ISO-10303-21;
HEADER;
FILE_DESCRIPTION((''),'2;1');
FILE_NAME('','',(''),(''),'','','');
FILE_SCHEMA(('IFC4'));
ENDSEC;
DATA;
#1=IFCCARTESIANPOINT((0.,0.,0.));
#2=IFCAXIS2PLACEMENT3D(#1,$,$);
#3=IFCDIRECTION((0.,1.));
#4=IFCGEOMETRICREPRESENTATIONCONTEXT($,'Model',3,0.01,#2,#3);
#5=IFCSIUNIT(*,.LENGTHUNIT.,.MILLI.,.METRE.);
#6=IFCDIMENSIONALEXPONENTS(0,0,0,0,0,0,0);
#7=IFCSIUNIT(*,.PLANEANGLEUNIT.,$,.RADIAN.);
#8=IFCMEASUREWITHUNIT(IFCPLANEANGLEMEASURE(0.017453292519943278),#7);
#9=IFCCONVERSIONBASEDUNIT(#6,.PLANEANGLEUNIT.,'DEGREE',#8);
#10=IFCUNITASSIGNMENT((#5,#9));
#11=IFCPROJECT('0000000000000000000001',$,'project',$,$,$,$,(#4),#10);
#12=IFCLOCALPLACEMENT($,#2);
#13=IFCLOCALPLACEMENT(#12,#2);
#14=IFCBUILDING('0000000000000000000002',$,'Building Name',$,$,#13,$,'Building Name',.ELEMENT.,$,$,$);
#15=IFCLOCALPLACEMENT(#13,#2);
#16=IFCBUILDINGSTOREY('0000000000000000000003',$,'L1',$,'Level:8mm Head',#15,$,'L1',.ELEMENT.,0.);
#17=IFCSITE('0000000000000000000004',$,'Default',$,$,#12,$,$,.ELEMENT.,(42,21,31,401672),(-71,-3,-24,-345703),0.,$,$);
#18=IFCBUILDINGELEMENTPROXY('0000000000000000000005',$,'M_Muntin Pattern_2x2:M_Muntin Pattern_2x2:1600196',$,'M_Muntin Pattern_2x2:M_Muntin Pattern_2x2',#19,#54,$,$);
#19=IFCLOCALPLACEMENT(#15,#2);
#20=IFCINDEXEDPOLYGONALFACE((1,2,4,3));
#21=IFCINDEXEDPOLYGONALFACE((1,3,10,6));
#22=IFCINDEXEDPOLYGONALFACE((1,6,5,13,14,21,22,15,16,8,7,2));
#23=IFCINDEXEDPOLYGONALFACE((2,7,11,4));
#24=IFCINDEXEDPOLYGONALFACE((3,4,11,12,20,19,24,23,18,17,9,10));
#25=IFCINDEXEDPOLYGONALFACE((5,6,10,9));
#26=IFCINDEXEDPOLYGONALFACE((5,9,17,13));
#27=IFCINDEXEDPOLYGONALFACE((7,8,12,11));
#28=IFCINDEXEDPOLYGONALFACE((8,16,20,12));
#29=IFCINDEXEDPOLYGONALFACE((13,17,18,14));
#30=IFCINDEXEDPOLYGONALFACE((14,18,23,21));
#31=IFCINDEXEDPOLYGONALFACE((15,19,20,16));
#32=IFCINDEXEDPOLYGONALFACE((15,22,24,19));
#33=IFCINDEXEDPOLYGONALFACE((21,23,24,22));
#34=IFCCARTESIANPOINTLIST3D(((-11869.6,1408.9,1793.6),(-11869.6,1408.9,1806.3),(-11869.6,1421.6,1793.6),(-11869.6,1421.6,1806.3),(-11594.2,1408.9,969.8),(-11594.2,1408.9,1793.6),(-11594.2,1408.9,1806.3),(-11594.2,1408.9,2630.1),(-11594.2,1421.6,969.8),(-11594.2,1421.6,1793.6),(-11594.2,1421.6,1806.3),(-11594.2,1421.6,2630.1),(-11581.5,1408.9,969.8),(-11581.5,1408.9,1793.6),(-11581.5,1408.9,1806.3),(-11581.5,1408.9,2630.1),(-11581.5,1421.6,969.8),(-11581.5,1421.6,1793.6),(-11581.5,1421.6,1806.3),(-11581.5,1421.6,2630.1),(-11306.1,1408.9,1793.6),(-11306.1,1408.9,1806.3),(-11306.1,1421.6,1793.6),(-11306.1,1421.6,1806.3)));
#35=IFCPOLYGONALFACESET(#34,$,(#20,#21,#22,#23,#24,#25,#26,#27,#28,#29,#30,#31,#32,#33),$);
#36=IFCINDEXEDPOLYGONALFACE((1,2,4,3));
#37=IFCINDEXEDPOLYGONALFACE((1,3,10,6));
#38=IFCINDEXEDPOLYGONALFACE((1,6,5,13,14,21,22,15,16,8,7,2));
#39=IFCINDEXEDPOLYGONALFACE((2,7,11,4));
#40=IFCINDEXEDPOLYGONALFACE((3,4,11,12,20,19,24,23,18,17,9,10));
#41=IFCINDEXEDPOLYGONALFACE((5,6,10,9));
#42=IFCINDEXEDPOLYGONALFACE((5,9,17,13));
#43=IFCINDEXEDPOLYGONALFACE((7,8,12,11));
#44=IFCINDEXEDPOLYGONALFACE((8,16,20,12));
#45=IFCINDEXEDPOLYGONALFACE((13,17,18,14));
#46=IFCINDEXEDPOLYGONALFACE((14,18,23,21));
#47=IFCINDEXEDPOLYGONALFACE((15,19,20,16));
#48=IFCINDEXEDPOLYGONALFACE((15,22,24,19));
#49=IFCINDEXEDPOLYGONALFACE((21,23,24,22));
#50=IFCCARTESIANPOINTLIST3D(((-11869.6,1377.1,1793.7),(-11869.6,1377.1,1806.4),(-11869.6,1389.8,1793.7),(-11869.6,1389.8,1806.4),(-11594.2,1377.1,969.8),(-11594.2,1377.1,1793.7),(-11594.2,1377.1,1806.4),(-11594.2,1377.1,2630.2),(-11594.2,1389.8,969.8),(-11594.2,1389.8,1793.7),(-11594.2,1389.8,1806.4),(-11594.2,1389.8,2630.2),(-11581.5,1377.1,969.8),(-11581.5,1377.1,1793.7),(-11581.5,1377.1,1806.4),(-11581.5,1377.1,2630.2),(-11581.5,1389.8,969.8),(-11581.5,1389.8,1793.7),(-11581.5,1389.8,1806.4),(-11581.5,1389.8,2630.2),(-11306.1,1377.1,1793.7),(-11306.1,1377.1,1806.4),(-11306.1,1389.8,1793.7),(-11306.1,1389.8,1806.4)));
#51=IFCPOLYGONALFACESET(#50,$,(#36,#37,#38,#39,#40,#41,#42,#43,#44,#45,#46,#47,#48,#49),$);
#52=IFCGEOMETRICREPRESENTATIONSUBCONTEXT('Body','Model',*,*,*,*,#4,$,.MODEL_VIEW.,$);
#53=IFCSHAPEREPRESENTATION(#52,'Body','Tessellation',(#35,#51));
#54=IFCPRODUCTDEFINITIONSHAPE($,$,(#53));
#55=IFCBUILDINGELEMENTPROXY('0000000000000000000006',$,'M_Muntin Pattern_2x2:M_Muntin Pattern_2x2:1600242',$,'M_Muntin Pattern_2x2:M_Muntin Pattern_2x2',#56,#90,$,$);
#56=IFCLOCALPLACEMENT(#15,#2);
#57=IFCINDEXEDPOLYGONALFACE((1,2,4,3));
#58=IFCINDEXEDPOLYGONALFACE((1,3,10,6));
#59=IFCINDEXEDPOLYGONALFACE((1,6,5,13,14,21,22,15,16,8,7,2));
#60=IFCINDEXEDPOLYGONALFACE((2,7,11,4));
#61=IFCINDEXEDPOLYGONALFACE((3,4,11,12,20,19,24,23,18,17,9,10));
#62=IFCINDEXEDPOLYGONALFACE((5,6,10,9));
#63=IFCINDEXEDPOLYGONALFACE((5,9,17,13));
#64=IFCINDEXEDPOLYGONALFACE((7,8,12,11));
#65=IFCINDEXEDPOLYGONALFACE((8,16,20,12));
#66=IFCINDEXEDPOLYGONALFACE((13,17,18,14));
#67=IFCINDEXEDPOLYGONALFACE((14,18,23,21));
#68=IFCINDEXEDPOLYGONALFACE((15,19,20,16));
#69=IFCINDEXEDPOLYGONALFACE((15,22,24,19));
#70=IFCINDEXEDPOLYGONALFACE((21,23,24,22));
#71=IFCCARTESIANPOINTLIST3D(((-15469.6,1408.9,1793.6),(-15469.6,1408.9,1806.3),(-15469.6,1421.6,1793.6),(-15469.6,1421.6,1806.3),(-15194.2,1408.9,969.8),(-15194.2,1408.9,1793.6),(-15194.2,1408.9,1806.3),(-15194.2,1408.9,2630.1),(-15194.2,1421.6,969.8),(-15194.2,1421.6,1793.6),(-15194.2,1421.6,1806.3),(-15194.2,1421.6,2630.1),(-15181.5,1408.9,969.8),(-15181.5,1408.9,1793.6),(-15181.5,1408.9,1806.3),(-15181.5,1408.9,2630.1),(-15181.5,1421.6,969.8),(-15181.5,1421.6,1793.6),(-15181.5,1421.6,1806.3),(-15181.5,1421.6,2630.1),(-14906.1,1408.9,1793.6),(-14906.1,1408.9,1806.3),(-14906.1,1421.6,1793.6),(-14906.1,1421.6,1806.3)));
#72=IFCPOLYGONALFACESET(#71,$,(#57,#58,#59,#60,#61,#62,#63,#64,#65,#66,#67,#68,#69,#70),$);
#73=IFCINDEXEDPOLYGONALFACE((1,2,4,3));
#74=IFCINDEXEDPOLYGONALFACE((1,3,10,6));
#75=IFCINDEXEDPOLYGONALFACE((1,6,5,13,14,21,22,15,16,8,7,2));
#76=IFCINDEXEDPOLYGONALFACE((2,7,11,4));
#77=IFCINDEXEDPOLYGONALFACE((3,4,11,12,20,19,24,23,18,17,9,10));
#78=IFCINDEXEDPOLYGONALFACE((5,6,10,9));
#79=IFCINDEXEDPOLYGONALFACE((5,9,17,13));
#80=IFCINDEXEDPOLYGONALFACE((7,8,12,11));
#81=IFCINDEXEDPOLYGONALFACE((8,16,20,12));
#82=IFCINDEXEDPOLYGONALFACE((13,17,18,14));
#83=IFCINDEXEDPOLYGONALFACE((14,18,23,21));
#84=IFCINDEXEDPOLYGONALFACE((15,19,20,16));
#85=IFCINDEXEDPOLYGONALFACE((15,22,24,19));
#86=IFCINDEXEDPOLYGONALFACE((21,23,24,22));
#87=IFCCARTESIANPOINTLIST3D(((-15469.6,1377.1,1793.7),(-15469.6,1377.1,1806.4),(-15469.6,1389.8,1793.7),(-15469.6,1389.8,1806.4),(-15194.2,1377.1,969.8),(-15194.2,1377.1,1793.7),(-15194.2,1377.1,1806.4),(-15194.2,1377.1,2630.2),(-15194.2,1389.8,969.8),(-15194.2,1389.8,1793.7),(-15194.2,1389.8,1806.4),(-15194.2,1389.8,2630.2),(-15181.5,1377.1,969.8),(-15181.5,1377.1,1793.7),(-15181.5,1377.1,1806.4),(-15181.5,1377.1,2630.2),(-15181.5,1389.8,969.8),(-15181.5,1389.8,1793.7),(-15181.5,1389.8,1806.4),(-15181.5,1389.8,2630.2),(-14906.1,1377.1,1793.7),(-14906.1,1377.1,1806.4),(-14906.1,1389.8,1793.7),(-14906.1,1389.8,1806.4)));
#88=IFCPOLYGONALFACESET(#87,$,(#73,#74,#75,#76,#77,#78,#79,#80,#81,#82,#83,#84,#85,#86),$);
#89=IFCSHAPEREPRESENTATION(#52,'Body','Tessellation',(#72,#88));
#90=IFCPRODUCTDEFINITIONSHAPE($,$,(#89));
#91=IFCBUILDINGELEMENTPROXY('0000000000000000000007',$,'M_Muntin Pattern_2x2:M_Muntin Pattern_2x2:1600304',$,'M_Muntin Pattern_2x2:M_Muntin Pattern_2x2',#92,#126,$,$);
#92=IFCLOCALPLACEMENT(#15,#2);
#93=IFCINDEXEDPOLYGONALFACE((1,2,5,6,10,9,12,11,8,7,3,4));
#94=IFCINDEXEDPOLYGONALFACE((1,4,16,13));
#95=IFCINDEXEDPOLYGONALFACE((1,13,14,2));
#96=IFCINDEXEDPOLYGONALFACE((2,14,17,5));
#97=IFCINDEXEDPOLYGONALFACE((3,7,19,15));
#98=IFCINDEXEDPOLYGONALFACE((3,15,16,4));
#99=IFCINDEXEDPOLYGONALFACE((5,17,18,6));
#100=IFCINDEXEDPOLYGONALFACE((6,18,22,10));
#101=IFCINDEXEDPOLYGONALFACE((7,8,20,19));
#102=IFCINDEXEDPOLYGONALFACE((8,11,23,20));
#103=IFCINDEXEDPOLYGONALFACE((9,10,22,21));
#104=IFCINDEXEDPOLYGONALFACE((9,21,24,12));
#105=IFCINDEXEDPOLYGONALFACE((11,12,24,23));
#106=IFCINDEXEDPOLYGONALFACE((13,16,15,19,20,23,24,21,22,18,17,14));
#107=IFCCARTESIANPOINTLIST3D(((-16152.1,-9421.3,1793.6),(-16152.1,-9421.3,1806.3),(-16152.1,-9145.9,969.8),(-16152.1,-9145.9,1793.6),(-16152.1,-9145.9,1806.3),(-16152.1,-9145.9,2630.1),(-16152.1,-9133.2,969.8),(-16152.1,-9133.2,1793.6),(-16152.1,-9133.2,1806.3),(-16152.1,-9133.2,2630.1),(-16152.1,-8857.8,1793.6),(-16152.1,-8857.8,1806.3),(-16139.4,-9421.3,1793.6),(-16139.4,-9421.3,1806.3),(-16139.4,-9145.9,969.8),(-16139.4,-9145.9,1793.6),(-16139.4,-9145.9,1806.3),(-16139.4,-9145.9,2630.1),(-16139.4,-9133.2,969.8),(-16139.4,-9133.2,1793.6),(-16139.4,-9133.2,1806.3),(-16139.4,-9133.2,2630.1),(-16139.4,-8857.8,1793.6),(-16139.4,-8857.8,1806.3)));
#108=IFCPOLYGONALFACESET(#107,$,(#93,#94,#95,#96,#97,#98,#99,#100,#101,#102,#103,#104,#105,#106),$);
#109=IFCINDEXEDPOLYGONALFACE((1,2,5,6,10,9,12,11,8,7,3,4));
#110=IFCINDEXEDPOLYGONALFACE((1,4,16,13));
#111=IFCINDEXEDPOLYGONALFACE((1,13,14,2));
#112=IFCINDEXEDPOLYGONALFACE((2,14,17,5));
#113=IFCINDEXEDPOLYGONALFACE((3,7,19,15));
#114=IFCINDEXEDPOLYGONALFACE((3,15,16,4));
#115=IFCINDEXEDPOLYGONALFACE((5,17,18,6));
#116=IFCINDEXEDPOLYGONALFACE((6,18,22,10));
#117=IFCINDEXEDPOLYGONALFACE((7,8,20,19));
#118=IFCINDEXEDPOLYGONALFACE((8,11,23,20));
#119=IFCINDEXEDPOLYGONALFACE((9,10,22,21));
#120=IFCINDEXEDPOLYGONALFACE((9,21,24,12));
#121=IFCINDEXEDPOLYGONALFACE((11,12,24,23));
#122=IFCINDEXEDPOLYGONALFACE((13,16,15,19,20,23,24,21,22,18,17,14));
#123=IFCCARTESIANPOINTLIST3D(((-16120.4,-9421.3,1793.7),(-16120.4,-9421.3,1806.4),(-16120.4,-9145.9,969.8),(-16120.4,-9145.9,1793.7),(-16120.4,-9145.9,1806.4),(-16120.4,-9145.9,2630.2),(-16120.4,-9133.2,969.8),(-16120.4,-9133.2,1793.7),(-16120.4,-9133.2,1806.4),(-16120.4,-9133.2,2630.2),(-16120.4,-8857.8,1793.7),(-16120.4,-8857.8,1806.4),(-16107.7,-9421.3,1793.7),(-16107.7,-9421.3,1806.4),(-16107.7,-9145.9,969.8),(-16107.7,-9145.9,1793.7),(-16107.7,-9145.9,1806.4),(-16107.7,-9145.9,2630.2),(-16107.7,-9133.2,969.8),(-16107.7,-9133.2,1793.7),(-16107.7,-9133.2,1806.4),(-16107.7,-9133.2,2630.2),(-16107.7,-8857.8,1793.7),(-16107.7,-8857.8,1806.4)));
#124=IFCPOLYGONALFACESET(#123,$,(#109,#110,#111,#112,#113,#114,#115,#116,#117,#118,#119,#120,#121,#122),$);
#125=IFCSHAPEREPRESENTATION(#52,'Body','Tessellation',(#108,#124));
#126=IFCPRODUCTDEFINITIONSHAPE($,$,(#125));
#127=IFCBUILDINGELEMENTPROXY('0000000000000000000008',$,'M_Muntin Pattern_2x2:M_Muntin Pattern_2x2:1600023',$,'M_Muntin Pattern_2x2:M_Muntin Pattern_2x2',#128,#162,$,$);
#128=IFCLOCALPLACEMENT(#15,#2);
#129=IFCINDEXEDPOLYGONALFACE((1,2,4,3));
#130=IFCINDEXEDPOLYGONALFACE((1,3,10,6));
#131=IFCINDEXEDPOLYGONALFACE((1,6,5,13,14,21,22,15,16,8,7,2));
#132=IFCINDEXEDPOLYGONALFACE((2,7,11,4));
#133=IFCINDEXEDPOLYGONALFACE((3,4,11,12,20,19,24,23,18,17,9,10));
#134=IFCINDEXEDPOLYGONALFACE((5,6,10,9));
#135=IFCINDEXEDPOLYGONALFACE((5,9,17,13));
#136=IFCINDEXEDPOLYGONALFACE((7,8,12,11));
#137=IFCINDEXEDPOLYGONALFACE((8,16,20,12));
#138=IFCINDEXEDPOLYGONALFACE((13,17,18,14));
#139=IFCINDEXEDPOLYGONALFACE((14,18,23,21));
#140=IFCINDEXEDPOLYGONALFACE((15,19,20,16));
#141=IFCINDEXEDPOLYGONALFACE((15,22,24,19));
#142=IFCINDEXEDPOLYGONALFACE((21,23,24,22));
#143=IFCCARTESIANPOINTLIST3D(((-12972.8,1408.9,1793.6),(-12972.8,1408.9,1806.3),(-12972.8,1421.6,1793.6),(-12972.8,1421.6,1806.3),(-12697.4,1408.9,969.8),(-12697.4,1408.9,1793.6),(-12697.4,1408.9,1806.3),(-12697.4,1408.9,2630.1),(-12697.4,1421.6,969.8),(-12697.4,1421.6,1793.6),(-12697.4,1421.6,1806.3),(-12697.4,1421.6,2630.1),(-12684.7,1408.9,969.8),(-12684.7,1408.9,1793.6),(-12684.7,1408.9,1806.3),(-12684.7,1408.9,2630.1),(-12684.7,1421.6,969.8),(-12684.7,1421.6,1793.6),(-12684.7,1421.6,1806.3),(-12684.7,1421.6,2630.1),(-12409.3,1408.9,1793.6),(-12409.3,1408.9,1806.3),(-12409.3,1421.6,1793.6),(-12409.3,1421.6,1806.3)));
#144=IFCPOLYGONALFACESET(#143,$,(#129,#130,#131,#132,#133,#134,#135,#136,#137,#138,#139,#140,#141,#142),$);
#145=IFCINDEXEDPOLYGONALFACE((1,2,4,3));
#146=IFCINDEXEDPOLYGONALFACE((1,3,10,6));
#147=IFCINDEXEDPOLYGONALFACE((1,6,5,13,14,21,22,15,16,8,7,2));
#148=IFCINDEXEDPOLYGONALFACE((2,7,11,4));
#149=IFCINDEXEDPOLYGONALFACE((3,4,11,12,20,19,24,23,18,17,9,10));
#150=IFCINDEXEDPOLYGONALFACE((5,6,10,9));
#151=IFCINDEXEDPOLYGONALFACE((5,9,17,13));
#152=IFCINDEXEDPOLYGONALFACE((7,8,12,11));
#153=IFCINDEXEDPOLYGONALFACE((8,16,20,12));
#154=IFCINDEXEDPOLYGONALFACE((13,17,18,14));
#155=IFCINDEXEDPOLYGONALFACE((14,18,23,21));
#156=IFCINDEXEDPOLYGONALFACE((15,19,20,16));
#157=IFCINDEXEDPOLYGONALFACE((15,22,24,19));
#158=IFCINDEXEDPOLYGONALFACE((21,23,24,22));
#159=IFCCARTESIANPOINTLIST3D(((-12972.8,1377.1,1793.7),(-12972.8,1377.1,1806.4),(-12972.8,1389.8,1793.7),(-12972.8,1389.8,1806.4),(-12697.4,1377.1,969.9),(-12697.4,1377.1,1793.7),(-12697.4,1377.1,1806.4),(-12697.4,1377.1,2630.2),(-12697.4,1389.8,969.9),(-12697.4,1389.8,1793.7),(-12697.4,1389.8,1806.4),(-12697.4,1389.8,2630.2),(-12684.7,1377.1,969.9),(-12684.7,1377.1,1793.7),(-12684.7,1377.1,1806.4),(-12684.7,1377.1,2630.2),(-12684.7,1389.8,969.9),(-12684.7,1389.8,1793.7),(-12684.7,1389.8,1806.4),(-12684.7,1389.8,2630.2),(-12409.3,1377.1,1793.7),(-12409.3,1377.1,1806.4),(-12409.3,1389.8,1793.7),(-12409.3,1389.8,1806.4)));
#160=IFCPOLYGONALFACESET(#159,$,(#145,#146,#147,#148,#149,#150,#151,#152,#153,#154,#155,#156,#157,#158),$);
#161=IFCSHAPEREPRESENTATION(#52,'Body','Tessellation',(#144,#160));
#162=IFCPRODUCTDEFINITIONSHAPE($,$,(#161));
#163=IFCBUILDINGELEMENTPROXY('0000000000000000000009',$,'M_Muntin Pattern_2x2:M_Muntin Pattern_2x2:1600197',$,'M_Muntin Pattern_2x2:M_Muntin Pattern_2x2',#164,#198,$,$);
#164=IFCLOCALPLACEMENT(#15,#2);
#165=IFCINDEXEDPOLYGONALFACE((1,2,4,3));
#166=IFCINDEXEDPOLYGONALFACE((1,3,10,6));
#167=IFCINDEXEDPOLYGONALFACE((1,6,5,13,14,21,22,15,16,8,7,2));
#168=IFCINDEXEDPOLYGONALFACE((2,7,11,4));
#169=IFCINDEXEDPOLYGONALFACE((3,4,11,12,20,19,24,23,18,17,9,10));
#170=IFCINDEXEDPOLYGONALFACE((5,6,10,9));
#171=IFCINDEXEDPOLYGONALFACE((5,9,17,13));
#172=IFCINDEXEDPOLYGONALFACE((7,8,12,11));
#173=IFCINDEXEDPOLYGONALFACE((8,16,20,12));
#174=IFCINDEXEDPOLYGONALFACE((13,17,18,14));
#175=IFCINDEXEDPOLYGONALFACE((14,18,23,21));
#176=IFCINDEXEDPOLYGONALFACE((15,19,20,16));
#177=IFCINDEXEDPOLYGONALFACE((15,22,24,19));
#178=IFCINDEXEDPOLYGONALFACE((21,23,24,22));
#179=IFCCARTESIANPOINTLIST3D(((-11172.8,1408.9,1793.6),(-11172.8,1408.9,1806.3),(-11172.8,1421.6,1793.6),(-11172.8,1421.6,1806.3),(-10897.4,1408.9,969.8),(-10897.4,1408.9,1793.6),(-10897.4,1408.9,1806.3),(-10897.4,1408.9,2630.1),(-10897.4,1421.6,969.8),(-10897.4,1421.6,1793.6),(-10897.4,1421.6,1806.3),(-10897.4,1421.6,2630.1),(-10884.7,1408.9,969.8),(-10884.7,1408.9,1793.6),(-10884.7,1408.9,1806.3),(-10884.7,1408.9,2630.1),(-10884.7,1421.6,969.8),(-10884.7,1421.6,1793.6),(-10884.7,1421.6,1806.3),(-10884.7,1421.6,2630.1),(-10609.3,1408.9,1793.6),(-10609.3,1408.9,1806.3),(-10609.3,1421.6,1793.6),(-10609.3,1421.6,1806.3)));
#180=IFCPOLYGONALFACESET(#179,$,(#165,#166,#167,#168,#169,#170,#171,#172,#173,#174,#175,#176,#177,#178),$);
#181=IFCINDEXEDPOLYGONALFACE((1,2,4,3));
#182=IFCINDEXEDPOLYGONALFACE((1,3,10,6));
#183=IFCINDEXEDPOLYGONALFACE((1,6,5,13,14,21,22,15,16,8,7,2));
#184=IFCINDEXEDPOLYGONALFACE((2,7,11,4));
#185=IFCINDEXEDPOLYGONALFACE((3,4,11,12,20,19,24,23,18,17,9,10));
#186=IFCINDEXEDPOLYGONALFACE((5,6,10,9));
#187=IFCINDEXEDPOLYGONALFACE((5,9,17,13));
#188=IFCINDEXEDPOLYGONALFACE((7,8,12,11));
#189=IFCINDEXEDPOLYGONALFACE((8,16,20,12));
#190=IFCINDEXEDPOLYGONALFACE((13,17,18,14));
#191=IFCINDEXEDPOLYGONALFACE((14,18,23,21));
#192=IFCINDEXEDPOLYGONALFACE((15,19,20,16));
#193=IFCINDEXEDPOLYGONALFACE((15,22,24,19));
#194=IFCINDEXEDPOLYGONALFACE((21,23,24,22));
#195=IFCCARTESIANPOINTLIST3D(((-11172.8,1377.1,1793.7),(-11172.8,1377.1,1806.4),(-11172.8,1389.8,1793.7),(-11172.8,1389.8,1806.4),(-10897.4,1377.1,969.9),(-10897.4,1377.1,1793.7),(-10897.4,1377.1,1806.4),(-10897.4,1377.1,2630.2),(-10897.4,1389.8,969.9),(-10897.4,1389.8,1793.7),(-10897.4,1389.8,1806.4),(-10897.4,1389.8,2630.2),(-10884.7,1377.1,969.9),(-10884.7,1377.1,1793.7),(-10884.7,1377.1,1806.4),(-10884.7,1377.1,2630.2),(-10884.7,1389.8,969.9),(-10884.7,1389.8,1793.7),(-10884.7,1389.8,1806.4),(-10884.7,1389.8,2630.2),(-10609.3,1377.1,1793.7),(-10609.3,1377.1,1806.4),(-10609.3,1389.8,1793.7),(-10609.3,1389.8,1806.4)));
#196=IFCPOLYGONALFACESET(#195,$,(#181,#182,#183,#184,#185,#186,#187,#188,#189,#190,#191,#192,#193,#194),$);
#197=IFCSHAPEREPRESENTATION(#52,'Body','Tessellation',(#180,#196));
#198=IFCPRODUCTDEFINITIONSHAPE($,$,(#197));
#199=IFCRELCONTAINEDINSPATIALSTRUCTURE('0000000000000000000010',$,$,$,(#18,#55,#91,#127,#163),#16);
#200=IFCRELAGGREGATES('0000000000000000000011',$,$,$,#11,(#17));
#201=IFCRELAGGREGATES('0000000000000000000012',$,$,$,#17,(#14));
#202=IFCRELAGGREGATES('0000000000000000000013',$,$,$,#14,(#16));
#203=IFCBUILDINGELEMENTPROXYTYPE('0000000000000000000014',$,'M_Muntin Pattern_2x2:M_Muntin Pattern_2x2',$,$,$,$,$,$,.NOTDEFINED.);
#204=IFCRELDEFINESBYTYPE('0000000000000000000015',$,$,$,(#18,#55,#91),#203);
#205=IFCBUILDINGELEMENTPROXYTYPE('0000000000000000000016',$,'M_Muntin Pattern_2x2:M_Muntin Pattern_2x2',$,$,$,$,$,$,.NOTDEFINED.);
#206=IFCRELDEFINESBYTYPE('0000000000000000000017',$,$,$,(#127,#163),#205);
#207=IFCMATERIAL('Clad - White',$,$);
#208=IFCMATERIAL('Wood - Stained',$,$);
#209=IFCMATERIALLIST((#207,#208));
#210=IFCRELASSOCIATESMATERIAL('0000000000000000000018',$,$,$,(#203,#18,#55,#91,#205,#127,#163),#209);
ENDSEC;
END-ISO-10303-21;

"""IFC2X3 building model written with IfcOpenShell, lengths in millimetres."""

from ifc_helpers import new_model, entity, si_unit, converted_unit, direction, frame, origin, place, context, subcontext, project, spatial, polyline, outline, extrude, source, transform, mapped, material, material_list, type_object, type_shapes, element, save


model = new_model("IFC2X3")

# Units and contexts
model_context = context("Model", 3, precision=0.01, world=origin(), true_north=direction((0.0, 1.0)))
body_context = subcontext(model_context, "Body", "Model", "MODEL_VIEW")
ifc_project = project(units=[si_unit("LENGTHUNIT", "METRE", prefix="MILLI"), converted_unit("PLANEANGLEUNIT", "DEGREE", entity("IfcPlaneAngleMeasure", 0.017453292519943278), si_unit("PLANEANGLEUNIT", "RADIAN"), dimensions=[0, 0, 0, 0, 0, 0, 0])], contexts=[model_context])

# Site, building, storey
site_placement = place(None, origin())
site = spatial("IfcSite", under=ifc_project, at=site_placement, Name="Default", CompositionType="ELEMENT", RefLatitude=(42, 21, 31, 401672), RefLongitude=(-71, -3, -24, -345703), RefElevation=0.0)
building_placement = place(site_placement, origin())
building = spatial("IfcBuilding", under=site, at=building_placement, Name="Building Name", LongName="Building Name", CompositionType="ELEMENT")
storey_placement = place(building_placement, origin())
storey = spatial("IfcBuildingStorey", under=building, at=storey_placement, Name="L1", ObjectType="Level:8mm Head", LongName="L1", CompositionType="ELEMENT", Elevation=0.0)

# Building element proxies
ifc_material_1 = material(Name="Clad - White")
ifc_material_2 = material(Name="Wood - Stained")
ifc_material_list = material_list([ifc_material_1, ifc_material_2])
building_element_proxy_type_1 = type_object("IfcBuildingElementProxyType", Name="M_Muntin Pattern_2x2:M_Muntin Pattern_2x2", PredefinedType="NOTDEFINED", material=ifc_material_list)
shared_shape_1 = source(origin(), body_context, "Body", "SweptSolid", [
    extrude(outline(polyline([(6.4, -6.4), (830.1, -6.4), (830.1, 6.3), (6.4, 6.3), (6.4, 281.7), (-6.3, 281.7), (-6.3, 6.3), (-830.2, 6.3), (-830.2, -6.4), (-6.3, -6.4), (-6.3, -281.7), (6.4, -281.7), (6.4, -6.4)])), frame((0.0, 9.5, 830.1), z_axis=(0.0, 1.0, 0.0), x_axis=(0.0, 0.0, 1.0)), (0.0, 0.0, 1.0), 12.7),
    extrude(outline(polyline([(6.4, -6.4), (830.2, -6.4), (830.2, 6.3), (6.4, 6.3), (6.4, 281.7), (-6.3, 281.7), (-6.3, 6.3), (-830.2, 6.3), (-830.2, -6.4), (-6.3, -6.4), (-6.3, -281.7), (6.4, -281.7), (6.4, -6.4)])), frame((0.0, -22.2, 830.2), z_axis=(0.0, 1.0, 0.0), x_axis=(0.0, 0.0, 1.0)), (0.0, 0.0, 1.0), 12.7),
])
type_shapes(building_element_proxy_type_1, [shared_shape_1])
for number, where, name in (
    (1, (-11587.9, 1399.4, 969.8), "M_Muntin Pattern_2x2:M_Muntin Pattern_2x2:1600196"),
    (2, (-15187.9, 1399.4, 969.8), "M_Muntin Pattern_2x2:M_Muntin Pattern_2x2:1600242"),
):
    element("IfcBuildingElementProxy", number, at=place(storey_placement, frame(where)), inside=storey, type_object=building_element_proxy_type_1, material=ifc_material_list, Name=name, ObjectType="M_Muntin Pattern_2x2:M_Muntin Pattern_2x2", context=body_context, shape_type="MappedRepresentation", body=[
        mapped(shared_shape_1, transform((0.0, 0.0, 0.0), scale=1.0)),
    ])
proxy_placement = place(storey_placement, frame((-16129.9, -9139.5, 969.8), z_axis=(0.0, 0.0, 1.0), x_axis=(0.0, 1.0, 0.0)))
element("IfcBuildingElementProxy", 3, at=proxy_placement, inside=storey, type_object=building_element_proxy_type_1, material=ifc_material_list, Name="M_Muntin Pattern_2x2:M_Muntin Pattern_2x2:1600304", ObjectType="M_Muntin Pattern_2x2:M_Muntin Pattern_2x2", context=body_context, shape_type="MappedRepresentation", body=[
    mapped(shared_shape_1, transform((0.0, 0.0, 0.0), scale=1.0)),
])
building_element_proxy_type_2 = type_object("IfcBuildingElementProxyType", Name="M_Muntin Pattern_2x2:M_Muntin Pattern_2x2", PredefinedType="NOTDEFINED", material=ifc_material_list)
shared_shape_2 = source(origin(), body_context, "Body", "SweptSolid", [
    extrude(outline(polyline([(6.4, -6.4), (830.1, -6.4), (830.1, 6.3), (6.4, 6.3), (6.4, 281.7), (-6.3, 281.7), (-6.3, 6.3), (-830.2, 6.3), (-830.2, -6.4), (-6.3, -6.4), (-6.3, -281.7), (6.4, -281.7), (6.4, -6.4)])), frame((0.0, -22.2, 830.1), z_axis=(0.0, 1.0, 0.0), x_axis=(0.0, 0.0, 1.0)), (0.0, 0.0, 1.0), 12.7),
    extrude(outline(polyline([(6.4, -6.4), (830.2, -6.4), (830.2, 6.3), (6.4, 6.3), (6.4, 281.7), (-6.3, 281.7), (-6.3, 6.3), (-830.2, 6.3), (-830.2, -6.4), (-6.3, -6.4), (-6.3, -281.7), (6.4, -281.7), (6.4, -6.4)])), frame((0.0, 9.5, 830.2), z_axis=(0.0, 1.0, 0.0), x_axis=(0.0, 0.0, 1.0)), (0.0, 0.0, 1.0), 12.7),
])
type_shapes(building_element_proxy_type_2, [shared_shape_2])
for number, where, z_axis, x_axis, name in (
    (4, (-12691.0, 1399.4, 969.9), (0.0, 0.0, 1.0), (-1.0, 0.0, 0.0), "M_Muntin Pattern_2x2:M_Muntin Pattern_2x2:1600023"),
    (5, (-10891.0, 1399.4, 969.9), (0.0, 0.0, 1.0), (-1.0, 0.0, 0.0), "M_Muntin Pattern_2x2:M_Muntin Pattern_2x2:1600197"),
):
    element("IfcBuildingElementProxy", number, at=place(storey_placement, frame(where, z_axis=z_axis, x_axis=x_axis)), inside=storey, type_object=building_element_proxy_type_2, material=ifc_material_list, Name=name, ObjectType="M_Muntin Pattern_2x2:M_Muntin Pattern_2x2", context=body_context, shape_type="MappedRepresentation", body=[
        mapped(shared_shape_2, transform((0.0, 0.0, 0.0), scale=1.0)),
    ])

save(model, "model.ifc")
